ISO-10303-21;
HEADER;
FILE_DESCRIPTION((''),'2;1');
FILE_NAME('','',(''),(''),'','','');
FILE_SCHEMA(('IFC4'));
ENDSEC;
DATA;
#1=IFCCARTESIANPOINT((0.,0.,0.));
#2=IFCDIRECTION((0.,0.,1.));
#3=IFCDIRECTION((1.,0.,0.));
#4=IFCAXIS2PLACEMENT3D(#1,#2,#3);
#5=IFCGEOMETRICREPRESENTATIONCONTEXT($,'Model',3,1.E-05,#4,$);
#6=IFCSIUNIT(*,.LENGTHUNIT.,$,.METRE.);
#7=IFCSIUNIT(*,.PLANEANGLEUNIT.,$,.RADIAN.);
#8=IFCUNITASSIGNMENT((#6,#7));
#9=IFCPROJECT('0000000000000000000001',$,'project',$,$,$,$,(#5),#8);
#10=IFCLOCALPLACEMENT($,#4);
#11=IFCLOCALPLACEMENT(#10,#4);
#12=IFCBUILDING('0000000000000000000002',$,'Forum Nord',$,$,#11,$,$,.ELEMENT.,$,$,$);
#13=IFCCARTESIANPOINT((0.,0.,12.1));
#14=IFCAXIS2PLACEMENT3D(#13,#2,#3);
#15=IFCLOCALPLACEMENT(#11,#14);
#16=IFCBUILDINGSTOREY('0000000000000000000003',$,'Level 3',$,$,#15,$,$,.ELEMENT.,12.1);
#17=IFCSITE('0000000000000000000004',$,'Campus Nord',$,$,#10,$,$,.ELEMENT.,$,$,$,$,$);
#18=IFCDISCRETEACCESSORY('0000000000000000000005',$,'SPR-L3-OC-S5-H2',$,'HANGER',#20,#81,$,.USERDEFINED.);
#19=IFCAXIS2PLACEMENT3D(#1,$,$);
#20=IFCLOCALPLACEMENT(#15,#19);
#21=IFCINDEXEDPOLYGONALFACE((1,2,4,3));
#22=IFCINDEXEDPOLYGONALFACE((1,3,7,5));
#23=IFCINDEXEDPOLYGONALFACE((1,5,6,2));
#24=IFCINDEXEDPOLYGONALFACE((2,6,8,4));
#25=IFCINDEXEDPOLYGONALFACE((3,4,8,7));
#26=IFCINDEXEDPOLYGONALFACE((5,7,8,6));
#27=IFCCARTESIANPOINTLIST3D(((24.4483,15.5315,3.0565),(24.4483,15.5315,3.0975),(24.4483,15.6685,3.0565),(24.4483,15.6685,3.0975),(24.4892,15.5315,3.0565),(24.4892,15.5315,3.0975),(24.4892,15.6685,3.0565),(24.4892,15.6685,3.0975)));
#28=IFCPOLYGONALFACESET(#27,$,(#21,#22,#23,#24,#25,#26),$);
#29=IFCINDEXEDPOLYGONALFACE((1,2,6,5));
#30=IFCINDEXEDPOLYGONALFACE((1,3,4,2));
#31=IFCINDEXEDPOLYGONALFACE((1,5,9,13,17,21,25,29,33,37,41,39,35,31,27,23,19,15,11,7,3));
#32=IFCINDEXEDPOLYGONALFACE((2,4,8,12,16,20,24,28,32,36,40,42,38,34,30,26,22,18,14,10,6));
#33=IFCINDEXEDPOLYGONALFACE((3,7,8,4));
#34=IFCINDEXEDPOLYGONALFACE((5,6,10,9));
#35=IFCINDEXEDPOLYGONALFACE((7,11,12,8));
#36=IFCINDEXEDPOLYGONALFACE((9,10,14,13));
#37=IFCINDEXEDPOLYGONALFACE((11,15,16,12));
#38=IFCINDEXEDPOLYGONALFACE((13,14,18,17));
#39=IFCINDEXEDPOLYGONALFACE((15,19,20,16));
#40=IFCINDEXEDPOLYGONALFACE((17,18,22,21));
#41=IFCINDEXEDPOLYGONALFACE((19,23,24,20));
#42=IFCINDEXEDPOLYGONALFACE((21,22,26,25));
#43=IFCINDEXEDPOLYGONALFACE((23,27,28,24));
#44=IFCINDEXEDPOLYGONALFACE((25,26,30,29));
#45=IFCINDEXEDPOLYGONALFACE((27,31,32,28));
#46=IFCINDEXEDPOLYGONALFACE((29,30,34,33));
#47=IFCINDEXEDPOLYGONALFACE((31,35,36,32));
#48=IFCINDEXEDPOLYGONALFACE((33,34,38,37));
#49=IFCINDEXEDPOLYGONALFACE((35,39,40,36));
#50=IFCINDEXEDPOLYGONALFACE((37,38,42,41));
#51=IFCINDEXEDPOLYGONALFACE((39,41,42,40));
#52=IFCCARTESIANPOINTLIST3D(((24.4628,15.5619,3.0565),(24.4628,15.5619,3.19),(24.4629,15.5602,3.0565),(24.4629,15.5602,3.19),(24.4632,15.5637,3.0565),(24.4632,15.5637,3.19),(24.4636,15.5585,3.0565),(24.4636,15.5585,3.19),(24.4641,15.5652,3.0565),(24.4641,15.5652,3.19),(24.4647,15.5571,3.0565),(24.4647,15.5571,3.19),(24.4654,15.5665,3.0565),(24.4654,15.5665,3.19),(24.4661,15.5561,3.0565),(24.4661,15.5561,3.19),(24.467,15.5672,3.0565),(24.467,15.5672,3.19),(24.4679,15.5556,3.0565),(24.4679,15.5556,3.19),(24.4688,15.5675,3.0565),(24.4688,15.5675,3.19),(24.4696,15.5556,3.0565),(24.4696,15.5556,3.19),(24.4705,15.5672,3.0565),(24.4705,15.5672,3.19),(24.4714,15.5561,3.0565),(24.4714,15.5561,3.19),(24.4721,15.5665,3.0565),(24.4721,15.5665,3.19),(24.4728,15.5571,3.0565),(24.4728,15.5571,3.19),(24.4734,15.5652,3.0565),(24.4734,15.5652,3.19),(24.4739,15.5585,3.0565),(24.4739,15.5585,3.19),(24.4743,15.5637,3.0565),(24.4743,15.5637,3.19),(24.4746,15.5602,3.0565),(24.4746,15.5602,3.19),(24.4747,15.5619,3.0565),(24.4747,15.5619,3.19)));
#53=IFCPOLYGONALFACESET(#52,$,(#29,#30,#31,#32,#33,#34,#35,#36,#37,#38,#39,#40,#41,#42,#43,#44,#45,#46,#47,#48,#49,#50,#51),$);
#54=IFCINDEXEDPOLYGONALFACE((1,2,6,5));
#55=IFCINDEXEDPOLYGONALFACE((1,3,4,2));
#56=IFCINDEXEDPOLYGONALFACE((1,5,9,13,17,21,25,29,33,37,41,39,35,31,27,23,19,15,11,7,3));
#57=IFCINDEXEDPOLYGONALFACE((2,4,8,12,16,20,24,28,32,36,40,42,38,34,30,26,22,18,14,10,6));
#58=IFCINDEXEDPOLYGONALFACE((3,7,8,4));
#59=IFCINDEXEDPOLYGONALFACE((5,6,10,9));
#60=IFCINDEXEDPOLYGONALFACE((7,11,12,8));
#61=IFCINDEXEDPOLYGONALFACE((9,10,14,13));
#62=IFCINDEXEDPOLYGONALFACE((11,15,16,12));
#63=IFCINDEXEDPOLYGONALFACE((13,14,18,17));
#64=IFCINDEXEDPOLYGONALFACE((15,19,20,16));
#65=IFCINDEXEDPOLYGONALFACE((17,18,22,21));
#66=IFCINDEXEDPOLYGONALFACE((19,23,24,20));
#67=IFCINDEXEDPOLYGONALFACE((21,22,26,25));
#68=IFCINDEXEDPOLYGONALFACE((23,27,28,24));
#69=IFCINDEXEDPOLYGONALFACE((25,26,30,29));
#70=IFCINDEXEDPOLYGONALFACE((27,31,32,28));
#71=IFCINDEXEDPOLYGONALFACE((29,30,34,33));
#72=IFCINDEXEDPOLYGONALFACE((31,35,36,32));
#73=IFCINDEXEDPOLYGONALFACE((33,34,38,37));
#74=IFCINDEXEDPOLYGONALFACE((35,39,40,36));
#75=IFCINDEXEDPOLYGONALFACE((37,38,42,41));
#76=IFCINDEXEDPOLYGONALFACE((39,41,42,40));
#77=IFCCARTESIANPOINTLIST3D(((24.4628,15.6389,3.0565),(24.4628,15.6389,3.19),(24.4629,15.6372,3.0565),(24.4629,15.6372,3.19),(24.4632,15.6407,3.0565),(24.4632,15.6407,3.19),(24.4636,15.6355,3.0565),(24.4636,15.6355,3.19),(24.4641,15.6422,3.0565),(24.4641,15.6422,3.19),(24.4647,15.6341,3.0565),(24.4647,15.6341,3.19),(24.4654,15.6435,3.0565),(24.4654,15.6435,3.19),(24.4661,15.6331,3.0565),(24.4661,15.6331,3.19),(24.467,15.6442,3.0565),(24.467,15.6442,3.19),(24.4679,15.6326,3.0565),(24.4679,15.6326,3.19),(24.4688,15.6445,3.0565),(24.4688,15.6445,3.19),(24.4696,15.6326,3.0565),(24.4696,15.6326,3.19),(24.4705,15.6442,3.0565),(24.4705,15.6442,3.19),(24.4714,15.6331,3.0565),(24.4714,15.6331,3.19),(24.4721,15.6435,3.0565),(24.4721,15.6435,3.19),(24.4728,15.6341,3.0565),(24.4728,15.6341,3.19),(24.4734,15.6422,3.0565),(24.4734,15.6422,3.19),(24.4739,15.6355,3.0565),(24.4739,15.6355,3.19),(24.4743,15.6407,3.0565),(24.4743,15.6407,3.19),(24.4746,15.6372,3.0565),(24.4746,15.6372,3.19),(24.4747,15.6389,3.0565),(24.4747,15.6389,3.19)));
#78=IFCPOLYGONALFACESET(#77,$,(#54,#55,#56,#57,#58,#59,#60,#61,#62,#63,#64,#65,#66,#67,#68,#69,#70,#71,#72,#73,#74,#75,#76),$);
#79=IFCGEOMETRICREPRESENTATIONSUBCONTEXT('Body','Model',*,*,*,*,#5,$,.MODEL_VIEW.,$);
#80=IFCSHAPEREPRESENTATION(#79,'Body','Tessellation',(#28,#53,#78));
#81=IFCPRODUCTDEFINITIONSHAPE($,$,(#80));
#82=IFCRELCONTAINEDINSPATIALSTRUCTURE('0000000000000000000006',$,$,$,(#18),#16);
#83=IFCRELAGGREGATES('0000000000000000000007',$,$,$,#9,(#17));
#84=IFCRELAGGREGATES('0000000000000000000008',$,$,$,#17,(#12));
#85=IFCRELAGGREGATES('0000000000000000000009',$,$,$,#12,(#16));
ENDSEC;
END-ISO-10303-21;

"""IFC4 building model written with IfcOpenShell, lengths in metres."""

from ifc_helpers import new_model, si_unit, frame, frame_2d, origin_with_axes, origin_2d_with_axis, place, context, subcontext, project, spatial, rectangle, circle, extrude, element, save


model = new_model("IFC4")

# Units and contexts
model_context = context("Model", 3, precision=1e-05, world=origin_with_axes())
body_context = subcontext(model_context, "Body", "Model", "MODEL_VIEW")
ifc_project = project(units=[si_unit("LENGTHUNIT", "METRE"), si_unit("PLANEANGLEUNIT", "RADIAN")], contexts=[model_context])

# Site, building, storey
site_placement = place(None, origin_with_axes())
site = spatial("IfcSite", under=ifc_project, at=site_placement, Name="Campus Nord", CompositionType="ELEMENT")
building_placement = place(site_placement, origin_with_axes())
building = spatial("IfcBuilding", under=site, at=building_placement, Name="Forum Nord", CompositionType="ELEMENT")
storey_placement = place(building_placement, frame((0.0, 0.0, 12.1), z_axis=(0.0, 0.0, 1.0), x_axis=(1.0, 0.0, 0.0)))
storey = spatial("IfcBuildingStorey", under=building, at=storey_placement, Name="Level 3", CompositionType="ELEMENT", Elevation=12.1)

# Discrete accessory
for number, where, z_axis, x_axis, name in (
    (1, (24.4688, 15.6, 3.0975), (0.0, 0.0, 1.0), (0.0, 1.0, 0.0), "SPR-L3-OC-S5-H2"),
):
    element("IfcDiscreteAccessory", number, at=place(storey_placement, frame(where, z_axis=z_axis, x_axis=x_axis)), inside=storey, Name=name, ObjectType="HANGER", PredefinedType="USERDEFINED", context=body_context, shape_type="SweptSolid", body=[
        extrude(rectangle(XDim=0.137, YDim=0.041, at=origin_2d_with_axis()), frame((0.0, 0.0, -0.041), z_axis=(0.0, 0.0, 1.0), x_axis=(1.0, 0.0, 0.0)), (0.0, 0.0, 1.0), 0.041),
        extrude(circle(Radius=0.006, at=frame_2d((-0.0385, 0.0), x_axis=(1.0, 0.0))), frame((0.0, 0.0, -0.041), z_axis=(0.0, 0.0, 1.0), x_axis=(1.0, 0.0, 0.0)), (0.0, 0.0, 1.0), 0.1335),
        extrude(circle(Radius=0.006, at=frame_2d((0.0385, 0.0), x_axis=(1.0, 0.0))), frame((0.0, 0.0, -0.041), z_axis=(0.0, 0.0, 1.0), x_axis=(1.0, 0.0, 0.0)), (0.0, 0.0, 1.0), 0.1335),
    ])

save(model, "model.ifc")
